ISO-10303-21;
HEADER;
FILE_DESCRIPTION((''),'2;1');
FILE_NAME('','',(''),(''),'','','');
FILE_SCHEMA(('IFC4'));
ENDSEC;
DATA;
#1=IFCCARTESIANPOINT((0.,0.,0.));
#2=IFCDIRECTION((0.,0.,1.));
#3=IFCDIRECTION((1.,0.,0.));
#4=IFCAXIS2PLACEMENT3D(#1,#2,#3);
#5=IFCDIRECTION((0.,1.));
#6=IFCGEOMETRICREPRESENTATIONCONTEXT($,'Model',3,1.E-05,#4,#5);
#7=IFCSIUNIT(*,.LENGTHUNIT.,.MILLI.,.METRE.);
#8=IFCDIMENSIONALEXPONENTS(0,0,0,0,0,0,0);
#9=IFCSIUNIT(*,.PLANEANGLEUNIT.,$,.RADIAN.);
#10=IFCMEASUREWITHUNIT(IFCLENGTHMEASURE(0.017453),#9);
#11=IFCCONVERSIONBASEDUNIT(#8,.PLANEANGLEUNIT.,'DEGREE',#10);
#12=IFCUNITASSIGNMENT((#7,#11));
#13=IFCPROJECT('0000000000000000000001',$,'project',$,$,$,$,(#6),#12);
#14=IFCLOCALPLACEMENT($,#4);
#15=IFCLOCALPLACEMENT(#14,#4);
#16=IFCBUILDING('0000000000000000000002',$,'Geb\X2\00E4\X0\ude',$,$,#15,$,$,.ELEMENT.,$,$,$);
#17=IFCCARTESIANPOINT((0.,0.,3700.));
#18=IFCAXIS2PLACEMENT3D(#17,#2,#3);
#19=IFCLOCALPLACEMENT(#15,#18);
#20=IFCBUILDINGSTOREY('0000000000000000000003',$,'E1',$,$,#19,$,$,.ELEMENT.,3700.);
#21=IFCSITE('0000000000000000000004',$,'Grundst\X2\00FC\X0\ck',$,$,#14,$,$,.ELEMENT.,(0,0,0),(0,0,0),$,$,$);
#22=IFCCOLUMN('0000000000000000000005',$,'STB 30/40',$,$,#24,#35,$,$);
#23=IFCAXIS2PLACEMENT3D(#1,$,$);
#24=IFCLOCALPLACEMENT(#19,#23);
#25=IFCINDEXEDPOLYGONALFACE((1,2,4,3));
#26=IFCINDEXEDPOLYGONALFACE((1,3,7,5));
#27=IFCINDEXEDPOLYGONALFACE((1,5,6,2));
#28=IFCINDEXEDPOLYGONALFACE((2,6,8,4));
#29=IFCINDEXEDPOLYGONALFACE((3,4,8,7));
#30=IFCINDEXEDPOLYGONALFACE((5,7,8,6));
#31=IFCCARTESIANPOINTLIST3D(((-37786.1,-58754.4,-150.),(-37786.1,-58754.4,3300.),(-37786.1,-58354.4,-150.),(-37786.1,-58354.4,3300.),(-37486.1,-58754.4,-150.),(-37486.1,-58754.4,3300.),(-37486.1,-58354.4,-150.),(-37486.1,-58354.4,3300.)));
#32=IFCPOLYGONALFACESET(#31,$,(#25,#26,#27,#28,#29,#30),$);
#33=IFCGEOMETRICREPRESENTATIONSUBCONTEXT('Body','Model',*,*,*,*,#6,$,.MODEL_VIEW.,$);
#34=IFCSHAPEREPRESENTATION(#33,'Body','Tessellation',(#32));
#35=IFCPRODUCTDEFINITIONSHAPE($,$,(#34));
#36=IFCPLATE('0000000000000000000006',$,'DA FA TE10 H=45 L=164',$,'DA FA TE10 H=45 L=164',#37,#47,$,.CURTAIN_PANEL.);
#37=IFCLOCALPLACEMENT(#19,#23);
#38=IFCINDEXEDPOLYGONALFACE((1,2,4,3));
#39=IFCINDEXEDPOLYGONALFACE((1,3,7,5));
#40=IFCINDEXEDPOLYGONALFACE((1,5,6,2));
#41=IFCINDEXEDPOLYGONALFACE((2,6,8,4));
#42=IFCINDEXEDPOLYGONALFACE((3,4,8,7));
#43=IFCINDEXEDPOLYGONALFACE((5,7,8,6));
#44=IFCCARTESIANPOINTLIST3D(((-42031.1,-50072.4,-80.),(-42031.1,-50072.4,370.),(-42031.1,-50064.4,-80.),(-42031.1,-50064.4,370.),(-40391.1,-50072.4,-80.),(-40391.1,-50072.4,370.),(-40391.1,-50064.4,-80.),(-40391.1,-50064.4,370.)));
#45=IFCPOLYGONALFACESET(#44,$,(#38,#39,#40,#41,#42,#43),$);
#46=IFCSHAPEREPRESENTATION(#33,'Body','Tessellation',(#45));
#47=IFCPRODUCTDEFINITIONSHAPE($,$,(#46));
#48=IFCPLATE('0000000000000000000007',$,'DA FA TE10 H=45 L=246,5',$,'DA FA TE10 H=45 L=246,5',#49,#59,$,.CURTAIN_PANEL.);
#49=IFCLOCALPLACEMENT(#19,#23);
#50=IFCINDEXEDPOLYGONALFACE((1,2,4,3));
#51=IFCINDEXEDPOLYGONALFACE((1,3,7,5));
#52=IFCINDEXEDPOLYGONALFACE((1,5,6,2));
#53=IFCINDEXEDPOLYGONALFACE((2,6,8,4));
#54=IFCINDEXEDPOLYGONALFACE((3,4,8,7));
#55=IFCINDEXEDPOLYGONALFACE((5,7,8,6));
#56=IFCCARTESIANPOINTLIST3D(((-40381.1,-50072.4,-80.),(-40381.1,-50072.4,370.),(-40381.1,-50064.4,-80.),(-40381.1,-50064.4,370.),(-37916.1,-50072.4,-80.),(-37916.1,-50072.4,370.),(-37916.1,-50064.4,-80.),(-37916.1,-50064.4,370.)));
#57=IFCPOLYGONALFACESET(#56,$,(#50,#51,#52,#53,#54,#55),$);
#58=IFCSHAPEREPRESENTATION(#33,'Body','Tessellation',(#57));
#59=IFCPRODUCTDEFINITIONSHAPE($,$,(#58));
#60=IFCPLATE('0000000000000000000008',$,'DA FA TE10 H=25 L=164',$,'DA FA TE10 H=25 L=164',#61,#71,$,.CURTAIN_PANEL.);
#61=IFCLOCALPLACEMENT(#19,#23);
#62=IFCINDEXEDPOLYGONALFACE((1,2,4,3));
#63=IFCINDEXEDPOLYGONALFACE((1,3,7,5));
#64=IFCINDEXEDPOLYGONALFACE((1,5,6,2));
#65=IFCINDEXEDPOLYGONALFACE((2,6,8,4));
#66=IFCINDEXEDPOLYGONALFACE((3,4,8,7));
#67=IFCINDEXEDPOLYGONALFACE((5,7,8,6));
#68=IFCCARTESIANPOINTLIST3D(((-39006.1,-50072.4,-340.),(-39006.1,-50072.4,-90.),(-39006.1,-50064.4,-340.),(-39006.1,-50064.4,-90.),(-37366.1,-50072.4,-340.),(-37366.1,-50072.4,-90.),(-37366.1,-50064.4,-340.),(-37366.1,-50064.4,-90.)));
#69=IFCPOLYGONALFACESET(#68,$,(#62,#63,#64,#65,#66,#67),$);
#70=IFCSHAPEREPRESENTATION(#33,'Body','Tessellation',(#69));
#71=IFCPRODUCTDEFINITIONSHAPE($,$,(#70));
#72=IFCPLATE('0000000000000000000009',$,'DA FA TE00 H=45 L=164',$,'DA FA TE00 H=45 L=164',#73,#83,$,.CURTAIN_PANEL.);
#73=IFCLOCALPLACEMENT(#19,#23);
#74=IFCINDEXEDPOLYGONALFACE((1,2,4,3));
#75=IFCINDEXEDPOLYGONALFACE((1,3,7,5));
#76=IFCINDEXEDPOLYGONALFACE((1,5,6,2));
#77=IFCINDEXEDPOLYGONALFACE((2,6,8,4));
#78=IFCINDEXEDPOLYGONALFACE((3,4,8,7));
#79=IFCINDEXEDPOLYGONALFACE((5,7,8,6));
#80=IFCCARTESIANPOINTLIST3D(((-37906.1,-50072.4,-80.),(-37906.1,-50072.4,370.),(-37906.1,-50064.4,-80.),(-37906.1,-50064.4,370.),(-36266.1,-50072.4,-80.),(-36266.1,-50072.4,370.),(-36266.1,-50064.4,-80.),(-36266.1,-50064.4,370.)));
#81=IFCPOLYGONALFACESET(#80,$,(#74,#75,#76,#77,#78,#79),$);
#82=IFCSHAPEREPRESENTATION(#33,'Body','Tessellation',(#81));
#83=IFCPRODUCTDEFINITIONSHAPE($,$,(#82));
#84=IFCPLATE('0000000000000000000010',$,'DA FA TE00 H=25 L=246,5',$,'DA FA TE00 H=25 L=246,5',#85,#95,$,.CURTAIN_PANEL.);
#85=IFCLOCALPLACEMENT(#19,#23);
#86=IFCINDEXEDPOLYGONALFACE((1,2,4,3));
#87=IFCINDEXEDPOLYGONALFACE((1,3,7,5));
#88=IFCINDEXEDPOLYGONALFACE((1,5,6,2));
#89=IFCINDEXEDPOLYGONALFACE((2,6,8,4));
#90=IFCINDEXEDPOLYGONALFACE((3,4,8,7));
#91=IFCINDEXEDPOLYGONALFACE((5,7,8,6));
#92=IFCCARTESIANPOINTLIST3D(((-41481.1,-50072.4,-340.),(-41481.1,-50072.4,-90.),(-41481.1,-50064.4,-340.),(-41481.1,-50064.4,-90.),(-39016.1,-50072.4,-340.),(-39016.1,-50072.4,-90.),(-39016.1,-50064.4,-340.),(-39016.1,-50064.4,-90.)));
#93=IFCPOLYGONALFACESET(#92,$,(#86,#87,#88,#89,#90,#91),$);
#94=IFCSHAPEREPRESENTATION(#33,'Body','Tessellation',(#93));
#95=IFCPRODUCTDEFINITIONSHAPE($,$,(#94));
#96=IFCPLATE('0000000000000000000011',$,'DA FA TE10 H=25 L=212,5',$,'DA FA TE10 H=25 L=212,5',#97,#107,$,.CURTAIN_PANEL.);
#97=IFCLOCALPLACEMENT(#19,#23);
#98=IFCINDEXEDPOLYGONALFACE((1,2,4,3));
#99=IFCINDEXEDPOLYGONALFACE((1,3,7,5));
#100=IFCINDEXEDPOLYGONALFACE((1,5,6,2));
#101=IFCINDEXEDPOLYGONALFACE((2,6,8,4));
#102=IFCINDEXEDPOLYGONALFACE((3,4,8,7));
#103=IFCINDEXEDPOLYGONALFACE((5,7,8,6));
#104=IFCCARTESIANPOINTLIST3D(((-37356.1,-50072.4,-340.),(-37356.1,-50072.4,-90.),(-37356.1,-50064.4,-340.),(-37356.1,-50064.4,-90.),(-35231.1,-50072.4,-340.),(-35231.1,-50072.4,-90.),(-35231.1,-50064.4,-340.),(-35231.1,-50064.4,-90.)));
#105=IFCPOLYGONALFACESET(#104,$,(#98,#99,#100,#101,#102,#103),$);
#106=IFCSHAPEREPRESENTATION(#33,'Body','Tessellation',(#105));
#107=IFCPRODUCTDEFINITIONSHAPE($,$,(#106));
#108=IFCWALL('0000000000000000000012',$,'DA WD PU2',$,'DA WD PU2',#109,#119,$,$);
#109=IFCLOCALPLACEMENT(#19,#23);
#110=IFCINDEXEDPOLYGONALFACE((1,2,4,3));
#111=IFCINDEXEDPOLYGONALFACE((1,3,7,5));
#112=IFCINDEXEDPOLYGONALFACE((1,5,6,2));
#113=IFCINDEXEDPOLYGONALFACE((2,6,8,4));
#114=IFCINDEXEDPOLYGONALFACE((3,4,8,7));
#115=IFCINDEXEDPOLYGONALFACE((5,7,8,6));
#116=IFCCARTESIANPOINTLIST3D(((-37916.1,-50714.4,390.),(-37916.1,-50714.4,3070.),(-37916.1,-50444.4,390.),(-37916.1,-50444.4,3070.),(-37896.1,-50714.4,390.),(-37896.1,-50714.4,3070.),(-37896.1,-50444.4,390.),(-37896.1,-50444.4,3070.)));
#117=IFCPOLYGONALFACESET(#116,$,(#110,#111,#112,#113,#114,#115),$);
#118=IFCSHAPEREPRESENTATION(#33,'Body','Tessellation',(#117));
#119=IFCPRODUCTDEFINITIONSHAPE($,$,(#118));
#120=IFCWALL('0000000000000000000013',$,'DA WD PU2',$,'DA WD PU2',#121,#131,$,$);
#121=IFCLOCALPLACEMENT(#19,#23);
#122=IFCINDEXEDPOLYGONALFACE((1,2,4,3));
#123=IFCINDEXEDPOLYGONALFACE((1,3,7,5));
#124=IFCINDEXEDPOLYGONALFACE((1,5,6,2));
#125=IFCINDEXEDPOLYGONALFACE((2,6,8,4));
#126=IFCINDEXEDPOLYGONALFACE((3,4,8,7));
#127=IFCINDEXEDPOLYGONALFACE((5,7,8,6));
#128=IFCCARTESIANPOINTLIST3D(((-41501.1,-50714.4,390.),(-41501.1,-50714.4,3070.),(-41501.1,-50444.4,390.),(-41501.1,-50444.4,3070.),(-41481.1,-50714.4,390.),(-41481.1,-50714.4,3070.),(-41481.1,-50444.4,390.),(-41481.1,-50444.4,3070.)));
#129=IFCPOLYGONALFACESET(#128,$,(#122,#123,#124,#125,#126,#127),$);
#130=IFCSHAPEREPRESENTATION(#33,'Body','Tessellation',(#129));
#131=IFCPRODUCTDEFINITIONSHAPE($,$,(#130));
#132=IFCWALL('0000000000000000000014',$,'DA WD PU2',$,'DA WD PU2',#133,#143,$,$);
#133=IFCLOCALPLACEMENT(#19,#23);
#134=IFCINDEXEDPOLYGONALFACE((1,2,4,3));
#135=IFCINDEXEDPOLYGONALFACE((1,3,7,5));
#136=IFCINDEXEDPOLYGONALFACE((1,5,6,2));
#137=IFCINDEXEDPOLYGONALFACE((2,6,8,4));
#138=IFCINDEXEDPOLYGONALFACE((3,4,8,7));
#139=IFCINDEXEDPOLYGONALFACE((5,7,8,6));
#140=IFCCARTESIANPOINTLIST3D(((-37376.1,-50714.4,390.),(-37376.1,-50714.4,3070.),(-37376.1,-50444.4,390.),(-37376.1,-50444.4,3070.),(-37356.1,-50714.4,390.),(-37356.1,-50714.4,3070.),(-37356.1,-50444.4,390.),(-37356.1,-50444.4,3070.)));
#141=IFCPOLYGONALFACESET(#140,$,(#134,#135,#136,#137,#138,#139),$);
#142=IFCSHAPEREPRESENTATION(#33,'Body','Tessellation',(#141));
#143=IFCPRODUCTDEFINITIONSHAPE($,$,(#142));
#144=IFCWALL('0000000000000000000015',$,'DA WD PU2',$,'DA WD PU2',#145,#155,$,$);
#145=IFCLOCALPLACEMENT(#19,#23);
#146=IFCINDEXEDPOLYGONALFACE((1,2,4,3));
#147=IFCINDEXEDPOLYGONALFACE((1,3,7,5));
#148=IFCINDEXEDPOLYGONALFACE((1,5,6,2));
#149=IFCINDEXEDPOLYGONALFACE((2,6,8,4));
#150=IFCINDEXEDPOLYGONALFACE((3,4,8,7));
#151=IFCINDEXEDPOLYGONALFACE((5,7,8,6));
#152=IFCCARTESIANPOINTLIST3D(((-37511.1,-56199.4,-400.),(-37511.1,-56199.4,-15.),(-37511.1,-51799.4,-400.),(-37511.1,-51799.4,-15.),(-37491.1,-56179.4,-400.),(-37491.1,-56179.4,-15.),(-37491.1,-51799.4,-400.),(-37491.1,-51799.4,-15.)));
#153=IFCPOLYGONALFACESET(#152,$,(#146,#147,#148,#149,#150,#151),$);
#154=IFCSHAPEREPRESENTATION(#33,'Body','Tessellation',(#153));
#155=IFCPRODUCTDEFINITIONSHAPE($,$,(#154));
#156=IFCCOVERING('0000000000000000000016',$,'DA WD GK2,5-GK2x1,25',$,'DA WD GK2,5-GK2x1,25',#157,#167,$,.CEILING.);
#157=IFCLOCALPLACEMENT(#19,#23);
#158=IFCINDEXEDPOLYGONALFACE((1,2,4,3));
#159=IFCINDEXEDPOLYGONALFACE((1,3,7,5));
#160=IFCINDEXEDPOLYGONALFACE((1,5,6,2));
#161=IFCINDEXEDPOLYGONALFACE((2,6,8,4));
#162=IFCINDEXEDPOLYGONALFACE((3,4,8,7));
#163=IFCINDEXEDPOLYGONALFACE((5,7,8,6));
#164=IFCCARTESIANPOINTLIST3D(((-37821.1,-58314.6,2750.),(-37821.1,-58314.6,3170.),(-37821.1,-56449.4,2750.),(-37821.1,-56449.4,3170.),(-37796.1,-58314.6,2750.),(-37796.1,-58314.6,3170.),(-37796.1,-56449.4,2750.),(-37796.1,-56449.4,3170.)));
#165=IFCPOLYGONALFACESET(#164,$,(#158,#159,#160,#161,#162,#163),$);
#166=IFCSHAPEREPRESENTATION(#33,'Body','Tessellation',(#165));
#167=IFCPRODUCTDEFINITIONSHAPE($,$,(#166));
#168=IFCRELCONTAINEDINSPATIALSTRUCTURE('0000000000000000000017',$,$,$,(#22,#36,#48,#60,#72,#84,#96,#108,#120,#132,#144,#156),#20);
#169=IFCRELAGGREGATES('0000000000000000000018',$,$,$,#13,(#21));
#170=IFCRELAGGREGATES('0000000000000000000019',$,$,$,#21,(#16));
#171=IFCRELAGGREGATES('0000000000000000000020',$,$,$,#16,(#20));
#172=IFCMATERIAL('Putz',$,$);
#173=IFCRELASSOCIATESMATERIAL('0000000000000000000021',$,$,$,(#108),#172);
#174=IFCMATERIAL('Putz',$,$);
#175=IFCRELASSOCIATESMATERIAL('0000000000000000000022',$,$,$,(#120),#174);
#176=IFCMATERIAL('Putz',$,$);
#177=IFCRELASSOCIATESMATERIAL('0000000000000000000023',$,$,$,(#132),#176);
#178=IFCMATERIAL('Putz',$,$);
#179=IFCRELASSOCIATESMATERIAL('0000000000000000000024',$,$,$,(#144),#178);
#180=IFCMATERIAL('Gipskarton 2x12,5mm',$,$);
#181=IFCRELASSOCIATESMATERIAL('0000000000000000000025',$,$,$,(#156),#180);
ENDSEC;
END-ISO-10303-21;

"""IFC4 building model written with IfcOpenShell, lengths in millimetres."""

from ifc_helpers import new_model, entity, si_unit, converted_unit, direction, frame, origin_with_axes, place, context, subcontext, project, spatial, line, indexed_curve, outline, extrude, source, transform, mapped, material, element, save


model = new_model("IFC4")

# Units and contexts
model_context = context("Model", 3, precision=1e-05, world=origin_with_axes(), true_north=direction((0.0, 1.0)))
body_context = subcontext(model_context, "Body", "Model", "MODEL_VIEW")
ifc_project = project(units=[si_unit("LENGTHUNIT", "METRE", prefix="MILLI"), converted_unit("PLANEANGLEUNIT", "DEGREE", entity("IfcLengthMeasure", 0.017453), si_unit("PLANEANGLEUNIT", "RADIAN"), dimensions=[0, 0, 0, 0, 0, 0, 0])], contexts=[model_context])

# Site, building, storey
site_placement = place(None, origin_with_axes())
site = spatial("IfcSite", under=ifc_project, at=site_placement, Name="Grundstück", CompositionType="ELEMENT", RefLatitude=(0, 0, 0), RefLongitude=(0, 0, 0))
building_placement = place(site_placement, origin_with_axes())
building = spatial("IfcBuilding", under=site, at=building_placement, Name="Gebäude", CompositionType="ELEMENT")
storey_placement = place(building_placement, frame((0.0, 0.0, 3700.0), z_axis=(0.0, 0.0, 1.0), x_axis=(1.0, 0.0, 0.0)))
storey = spatial("IfcBuildingStorey", under=building, at=storey_placement, Name="E1", CompositionType="ELEMENT", Elevation=3700.0)

# Column
column_placement = place(storey_placement, frame((-37636.1, -58554.4, -150.0), z_axis=(0.0, 0.0, 1.0), x_axis=(1.0, 0.0, 0.0)))
element("IfcColumn", 1, at=column_placement, inside=storey, Name="STB 30/40", context=body_context, shape_type="SweptSolid", body=[
    extrude(outline(indexed_curve([(-150.0, -200.0), (150.0, -200.0), (150.0, 200.0), (-150.0, 200.0)], segments=[line(1, 2), line(2, 3), line(3, 4), line(4, 1)])), origin_with_axes(), (0.0, 0.0, 1.0), 3450.0),
])

# Plates
shared_shape_1 = source(origin_with_axes(), body_context, "Body", "SweptSolid", [
    extrude(outline(indexed_curve([(-820.0, 0.0), (820.0, 0.0), (820.0, 8.0), (-820.0, 8.0)], segments=[line(1, 2), line(2, 3), line(3, 4), line(4, 1)])), frame((0.0, 0.0, 450.0), z_axis=(0.0, 0.0, 1.0), x_axis=(1.0, 0.0, 0.0)), (0.0, 0.0, -1.0), 450.0),
])
plate_1_placement = place(storey_placement, frame((-41211.1, -50064.4, -80.0), z_axis=(0.0, 0.0, 1.0), x_axis=(-1.0, 0.0, 0.0)))
element("IfcPlate", 2, at=plate_1_placement, inside=storey, Name="DA FA TE10 H=45 L=164", ObjectType="DA FA TE10 H=45 L=164", PredefinedType="CURTAIN_PANEL", context=body_context, shape_type="MappedRepresentation", body=[
    mapped(shared_shape_1, transform((0.0, 0.0, 0.0), x_axis=(1.0, 0.0, 0.0), y_axis=(0.0, 1.0, 0.0), z_axis=(0.0, 0.0, 1.0), scale=1.0)),
])
shared_shape_2 = source(origin_with_axes(), body_context, "Body", "SweptSolid", [
    extrude(outline(indexed_curve([(-1232.5, 0.0), (1232.5, 0.0), (1232.5, 8.0), (-1232.5, 8.0)], segments=[line(1, 2), line(2, 3), line(3, 4), line(4, 1)])), frame((0.0, 0.0, 450.0), z_axis=(0.0, 0.0, 1.0), x_axis=(1.0, 0.0, 0.0)), (0.0, 0.0, -1.0), 450.0),
])
plate_2_placement = place(storey_placement, frame((-39148.6, -50064.4, -80.0), z_axis=(0.0, 0.0, 1.0), x_axis=(-1.0, 0.0, 0.0)))
element("IfcPlate", 3, at=plate_2_placement, inside=storey, Name="DA FA TE10 H=45 L=246,5", ObjectType="DA FA TE10 H=45 L=246,5", PredefinedType="CURTAIN_PANEL", context=body_context, shape_type="MappedRepresentation", body=[
    mapped(shared_shape_2, transform((0.0, 0.0, 0.0), x_axis=(1.0, 0.0, 0.0), y_axis=(0.0, 1.0, 0.0), z_axis=(0.0, 0.0, 1.0), scale=1.0)),
])
shared_shape_3 = source(origin_with_axes(), body_context, "Body", "SweptSolid", [
    extrude(outline(indexed_curve([(-820.0, 0.0), (820.0, 0.0), (820.0, 8.0), (-820.0, 8.0)], segments=[line(1, 2), line(2, 3), line(3, 4), line(4, 1)])), frame((0.0, 0.0, 250.0), z_axis=(0.0, 0.0, 1.0), x_axis=(1.0, 0.0, 0.0)), (0.0, 0.0, -1.0), 250.0),
])
plate_3_placement = place(storey_placement, frame((-38186.1, -50064.4, -340.0), z_axis=(0.0, 0.0, 1.0), x_axis=(-1.0, 0.0, 0.0)))
element("IfcPlate", 4, at=plate_3_placement, inside=storey, Name="DA FA TE10 H=25 L=164", ObjectType="DA FA TE10 H=25 L=164", PredefinedType="CURTAIN_PANEL", context=body_context, shape_type="MappedRepresentation", body=[
    mapped(shared_shape_3, transform((0.0, 0.0, 0.0), x_axis=(1.0, 0.0, 0.0), y_axis=(0.0, 1.0, 0.0), z_axis=(0.0, 0.0, 1.0), scale=1.0)),
])
shared_shape_4 = source(origin_with_axes(), body_context, "Body", "SweptSolid", [
    extrude(outline(indexed_curve([(-820.0, 0.0), (820.0, 0.0), (820.0, 8.0), (-820.0, 8.0)], segments=[line(1, 2), line(2, 3), line(3, 4), line(4, 1)])), frame((0.0, 0.0, 450.0), z_axis=(0.0, 0.0, 1.0), x_axis=(1.0, 0.0, 0.0)), (0.0, 0.0, -1.0), 450.0),
])
plate_4_placement = place(storey_placement, frame((-37086.1, -50064.4, -80.0), z_axis=(0.0, 0.0, 1.0), x_axis=(-1.0, 0.0, 0.0)))
element("IfcPlate", 5, at=plate_4_placement, inside=storey, Name="DA FA TE00 H=45 L=164", ObjectType="DA FA TE00 H=45 L=164", PredefinedType="CURTAIN_PANEL", context=body_context, shape_type="MappedRepresentation", body=[
    mapped(shared_shape_4, transform((0.0, 0.0, 0.0), x_axis=(1.0, 0.0, 0.0), y_axis=(0.0, 1.0, 0.0), z_axis=(0.0, 0.0, 1.0), scale=1.0)),
])
shared_shape_5 = source(origin_with_axes(), body_context, "Body", "SweptSolid", [
    extrude(outline(indexed_curve([(-1232.5, 0.0), (1232.5, 0.0), (1232.5, 8.0), (-1232.5, 8.0)], segments=[line(1, 2), line(2, 3), line(3, 4), line(4, 1)])), frame((0.0, 0.0, 250.0), z_axis=(0.0, 0.0, 1.0), x_axis=(1.0, 0.0, 0.0)), (0.0, 0.0, -1.0), 250.0),
])
plate_5_placement = place(storey_placement, frame((-40248.6, -50064.4, -340.0), z_axis=(0.0, 0.0, 1.0), x_axis=(-1.0, 0.0, 0.0)))
element("IfcPlate", 6, at=plate_5_placement, inside=storey, Name="DA FA TE00 H=25 L=246,5", ObjectType="DA FA TE00 H=25 L=246,5", PredefinedType="CURTAIN_PANEL", context=body_context, shape_type="MappedRepresentation", body=[
    mapped(shared_shape_5, transform((0.0, 0.0, 0.0), x_axis=(1.0, 0.0, 0.0), y_axis=(0.0, 1.0, 0.0), z_axis=(0.0, 0.0, 1.0), scale=1.0)),
])
shared_shape_6 = source(origin_with_axes(), body_context, "Body", "SweptSolid", [
    extrude(outline(indexed_curve([(-1062.5, 0.0), (1062.5, 0.0), (1062.5, 8.0), (-1062.5, 8.0)], segments=[line(1, 2), line(2, 3), line(3, 4), line(4, 1)])), frame((0.0, 0.0, 250.0), z_axis=(0.0, 0.0, 1.0), x_axis=(1.0, 0.0, 0.0)), (0.0, 0.0, -1.0), 250.0),
])
plate_6_placement = place(storey_placement, frame((-36293.6, -50064.4, -340.0), z_axis=(0.0, 0.0, 1.0), x_axis=(-1.0, 0.0, 0.0)))
element("IfcPlate", 7, at=plate_6_placement, inside=storey, Name="DA FA TE10 H=25 L=212,5", ObjectType="DA FA TE10 H=25 L=212,5", PredefinedType="CURTAIN_PANEL", context=body_context, shape_type="MappedRepresentation", body=[
    mapped(shared_shape_6, transform((0.0, 0.0, 0.0), x_axis=(1.0, 0.0, 0.0), y_axis=(0.0, 1.0, 0.0), z_axis=(0.0, 0.0, 1.0), scale=1.0)),
])

# Walls
ifc_material_1 = material(Name="Putz")
wall_1_placement = place(storey_placement, frame((-37906.1, -50444.4, 390.0), z_axis=(0.0, 0.0, 1.0), x_axis=(0.0, -1.0, 0.0)))
element("IfcWall", 8, at=wall_1_placement, inside=storey, material=ifc_material_1, Name="DA WD PU2", ObjectType="DA WD PU2", context=body_context, shape_type="SweptSolid", body=[
    extrude(outline(indexed_curve([(0.0, -10.0), (0.0, 10.0), (270.0, 10.0), (270.0, -10.0)], segments=[line(1, 2), line(2, 3), line(3, 4), line(4, 1)])), origin_with_axes(), (0.0, 0.0, 1.0), 2680.0),
])
ifc_material_2 = material(Name="Putz")
wall_2_placement = place(storey_placement, frame((-41491.1, -50444.4, 390.0), z_axis=(0.0, 0.0, 1.0), x_axis=(0.0, -1.0, 0.0)))
element("IfcWall", 9, at=wall_2_placement, inside=storey, material=ifc_material_2, Name="DA WD PU2", ObjectType="DA WD PU2", context=body_context, shape_type="SweptSolid", body=[
    extrude(outline(indexed_curve([(0.0, -10.0), (0.0, 10.0), (270.0, 10.0), (270.0, -10.0)], segments=[line(1, 2), line(2, 3), line(3, 4), line(4, 1)])), origin_with_axes(), (0.0, 0.0, 1.0), 2680.0),
])
ifc_material_3 = material(Name="Putz")
wall_3_placement = place(storey_placement, frame((-37366.1, -50444.4, 390.0), z_axis=(0.0, 0.0, 1.0), x_axis=(0.0, -1.0, 0.0)))
element("IfcWall", 10, at=wall_3_placement, inside=storey, material=ifc_material_3, Name="DA WD PU2", ObjectType="DA WD PU2", context=body_context, shape_type="SweptSolid", body=[
    extrude(outline(indexed_curve([(0.0, -10.0), (0.0, 10.0), (270.0, 10.0), (270.0, -10.0)], segments=[line(1, 2), line(2, 3), line(3, 4), line(4, 1)])), origin_with_axes(), (0.0, 0.0, 1.0), 2680.0),
])
ifc_material_4 = material(Name="Putz")
wall_4_placement = place(storey_placement, frame((-37501.1, -56189.4, -400.0), z_axis=(0.0, 0.0, 1.0), x_axis=(0.0, 1.0, 0.0)))
element("IfcWall", 11, at=wall_4_placement, inside=storey, material=ifc_material_4, Name="DA WD PU2", ObjectType="DA WD PU2", context=body_context, shape_type="SweptSolid", body=[
    extrude(outline(indexed_curve([(10.0, -10.0), (-10.0, 10.0), (4390.0, 10.0), (4390.0, -10.0)], segments=[line(1, 2), line(2, 3), line(3, 4), line(4, 1)])), origin_with_axes(), (0.0, 0.0, 1.0), 385.0),
])

# Covering
ifc_material_5 = material(Name="Gipskarton 2x12,5mm")
covering_placement = place(storey_placement, frame((-37808.6, -56449.4, 2750.0), z_axis=(0.0, 0.0, 1.0), x_axis=(0.0, -1.0, 0.0)))
element("IfcCovering", 12, at=covering_placement, inside=storey, material=ifc_material_5, Name="DA WD GK2,5-GK2x1,25", ObjectType="DA WD GK2,5-GK2x1,25", PredefinedType="CEILING", context=body_context, shape_type="SweptSolid", body=[
    extrude(outline(indexed_curve([(0.0, -12.5), (0.0, 12.5), (1865.2, 12.5), (1865.2, -12.5)], segments=[line(1, 2), line(2, 3), line(3, 4), line(4, 1)])), origin_with_axes(), (0.0, 0.0, 1.0), 420.0),
])

save(model, "model.ifc")
